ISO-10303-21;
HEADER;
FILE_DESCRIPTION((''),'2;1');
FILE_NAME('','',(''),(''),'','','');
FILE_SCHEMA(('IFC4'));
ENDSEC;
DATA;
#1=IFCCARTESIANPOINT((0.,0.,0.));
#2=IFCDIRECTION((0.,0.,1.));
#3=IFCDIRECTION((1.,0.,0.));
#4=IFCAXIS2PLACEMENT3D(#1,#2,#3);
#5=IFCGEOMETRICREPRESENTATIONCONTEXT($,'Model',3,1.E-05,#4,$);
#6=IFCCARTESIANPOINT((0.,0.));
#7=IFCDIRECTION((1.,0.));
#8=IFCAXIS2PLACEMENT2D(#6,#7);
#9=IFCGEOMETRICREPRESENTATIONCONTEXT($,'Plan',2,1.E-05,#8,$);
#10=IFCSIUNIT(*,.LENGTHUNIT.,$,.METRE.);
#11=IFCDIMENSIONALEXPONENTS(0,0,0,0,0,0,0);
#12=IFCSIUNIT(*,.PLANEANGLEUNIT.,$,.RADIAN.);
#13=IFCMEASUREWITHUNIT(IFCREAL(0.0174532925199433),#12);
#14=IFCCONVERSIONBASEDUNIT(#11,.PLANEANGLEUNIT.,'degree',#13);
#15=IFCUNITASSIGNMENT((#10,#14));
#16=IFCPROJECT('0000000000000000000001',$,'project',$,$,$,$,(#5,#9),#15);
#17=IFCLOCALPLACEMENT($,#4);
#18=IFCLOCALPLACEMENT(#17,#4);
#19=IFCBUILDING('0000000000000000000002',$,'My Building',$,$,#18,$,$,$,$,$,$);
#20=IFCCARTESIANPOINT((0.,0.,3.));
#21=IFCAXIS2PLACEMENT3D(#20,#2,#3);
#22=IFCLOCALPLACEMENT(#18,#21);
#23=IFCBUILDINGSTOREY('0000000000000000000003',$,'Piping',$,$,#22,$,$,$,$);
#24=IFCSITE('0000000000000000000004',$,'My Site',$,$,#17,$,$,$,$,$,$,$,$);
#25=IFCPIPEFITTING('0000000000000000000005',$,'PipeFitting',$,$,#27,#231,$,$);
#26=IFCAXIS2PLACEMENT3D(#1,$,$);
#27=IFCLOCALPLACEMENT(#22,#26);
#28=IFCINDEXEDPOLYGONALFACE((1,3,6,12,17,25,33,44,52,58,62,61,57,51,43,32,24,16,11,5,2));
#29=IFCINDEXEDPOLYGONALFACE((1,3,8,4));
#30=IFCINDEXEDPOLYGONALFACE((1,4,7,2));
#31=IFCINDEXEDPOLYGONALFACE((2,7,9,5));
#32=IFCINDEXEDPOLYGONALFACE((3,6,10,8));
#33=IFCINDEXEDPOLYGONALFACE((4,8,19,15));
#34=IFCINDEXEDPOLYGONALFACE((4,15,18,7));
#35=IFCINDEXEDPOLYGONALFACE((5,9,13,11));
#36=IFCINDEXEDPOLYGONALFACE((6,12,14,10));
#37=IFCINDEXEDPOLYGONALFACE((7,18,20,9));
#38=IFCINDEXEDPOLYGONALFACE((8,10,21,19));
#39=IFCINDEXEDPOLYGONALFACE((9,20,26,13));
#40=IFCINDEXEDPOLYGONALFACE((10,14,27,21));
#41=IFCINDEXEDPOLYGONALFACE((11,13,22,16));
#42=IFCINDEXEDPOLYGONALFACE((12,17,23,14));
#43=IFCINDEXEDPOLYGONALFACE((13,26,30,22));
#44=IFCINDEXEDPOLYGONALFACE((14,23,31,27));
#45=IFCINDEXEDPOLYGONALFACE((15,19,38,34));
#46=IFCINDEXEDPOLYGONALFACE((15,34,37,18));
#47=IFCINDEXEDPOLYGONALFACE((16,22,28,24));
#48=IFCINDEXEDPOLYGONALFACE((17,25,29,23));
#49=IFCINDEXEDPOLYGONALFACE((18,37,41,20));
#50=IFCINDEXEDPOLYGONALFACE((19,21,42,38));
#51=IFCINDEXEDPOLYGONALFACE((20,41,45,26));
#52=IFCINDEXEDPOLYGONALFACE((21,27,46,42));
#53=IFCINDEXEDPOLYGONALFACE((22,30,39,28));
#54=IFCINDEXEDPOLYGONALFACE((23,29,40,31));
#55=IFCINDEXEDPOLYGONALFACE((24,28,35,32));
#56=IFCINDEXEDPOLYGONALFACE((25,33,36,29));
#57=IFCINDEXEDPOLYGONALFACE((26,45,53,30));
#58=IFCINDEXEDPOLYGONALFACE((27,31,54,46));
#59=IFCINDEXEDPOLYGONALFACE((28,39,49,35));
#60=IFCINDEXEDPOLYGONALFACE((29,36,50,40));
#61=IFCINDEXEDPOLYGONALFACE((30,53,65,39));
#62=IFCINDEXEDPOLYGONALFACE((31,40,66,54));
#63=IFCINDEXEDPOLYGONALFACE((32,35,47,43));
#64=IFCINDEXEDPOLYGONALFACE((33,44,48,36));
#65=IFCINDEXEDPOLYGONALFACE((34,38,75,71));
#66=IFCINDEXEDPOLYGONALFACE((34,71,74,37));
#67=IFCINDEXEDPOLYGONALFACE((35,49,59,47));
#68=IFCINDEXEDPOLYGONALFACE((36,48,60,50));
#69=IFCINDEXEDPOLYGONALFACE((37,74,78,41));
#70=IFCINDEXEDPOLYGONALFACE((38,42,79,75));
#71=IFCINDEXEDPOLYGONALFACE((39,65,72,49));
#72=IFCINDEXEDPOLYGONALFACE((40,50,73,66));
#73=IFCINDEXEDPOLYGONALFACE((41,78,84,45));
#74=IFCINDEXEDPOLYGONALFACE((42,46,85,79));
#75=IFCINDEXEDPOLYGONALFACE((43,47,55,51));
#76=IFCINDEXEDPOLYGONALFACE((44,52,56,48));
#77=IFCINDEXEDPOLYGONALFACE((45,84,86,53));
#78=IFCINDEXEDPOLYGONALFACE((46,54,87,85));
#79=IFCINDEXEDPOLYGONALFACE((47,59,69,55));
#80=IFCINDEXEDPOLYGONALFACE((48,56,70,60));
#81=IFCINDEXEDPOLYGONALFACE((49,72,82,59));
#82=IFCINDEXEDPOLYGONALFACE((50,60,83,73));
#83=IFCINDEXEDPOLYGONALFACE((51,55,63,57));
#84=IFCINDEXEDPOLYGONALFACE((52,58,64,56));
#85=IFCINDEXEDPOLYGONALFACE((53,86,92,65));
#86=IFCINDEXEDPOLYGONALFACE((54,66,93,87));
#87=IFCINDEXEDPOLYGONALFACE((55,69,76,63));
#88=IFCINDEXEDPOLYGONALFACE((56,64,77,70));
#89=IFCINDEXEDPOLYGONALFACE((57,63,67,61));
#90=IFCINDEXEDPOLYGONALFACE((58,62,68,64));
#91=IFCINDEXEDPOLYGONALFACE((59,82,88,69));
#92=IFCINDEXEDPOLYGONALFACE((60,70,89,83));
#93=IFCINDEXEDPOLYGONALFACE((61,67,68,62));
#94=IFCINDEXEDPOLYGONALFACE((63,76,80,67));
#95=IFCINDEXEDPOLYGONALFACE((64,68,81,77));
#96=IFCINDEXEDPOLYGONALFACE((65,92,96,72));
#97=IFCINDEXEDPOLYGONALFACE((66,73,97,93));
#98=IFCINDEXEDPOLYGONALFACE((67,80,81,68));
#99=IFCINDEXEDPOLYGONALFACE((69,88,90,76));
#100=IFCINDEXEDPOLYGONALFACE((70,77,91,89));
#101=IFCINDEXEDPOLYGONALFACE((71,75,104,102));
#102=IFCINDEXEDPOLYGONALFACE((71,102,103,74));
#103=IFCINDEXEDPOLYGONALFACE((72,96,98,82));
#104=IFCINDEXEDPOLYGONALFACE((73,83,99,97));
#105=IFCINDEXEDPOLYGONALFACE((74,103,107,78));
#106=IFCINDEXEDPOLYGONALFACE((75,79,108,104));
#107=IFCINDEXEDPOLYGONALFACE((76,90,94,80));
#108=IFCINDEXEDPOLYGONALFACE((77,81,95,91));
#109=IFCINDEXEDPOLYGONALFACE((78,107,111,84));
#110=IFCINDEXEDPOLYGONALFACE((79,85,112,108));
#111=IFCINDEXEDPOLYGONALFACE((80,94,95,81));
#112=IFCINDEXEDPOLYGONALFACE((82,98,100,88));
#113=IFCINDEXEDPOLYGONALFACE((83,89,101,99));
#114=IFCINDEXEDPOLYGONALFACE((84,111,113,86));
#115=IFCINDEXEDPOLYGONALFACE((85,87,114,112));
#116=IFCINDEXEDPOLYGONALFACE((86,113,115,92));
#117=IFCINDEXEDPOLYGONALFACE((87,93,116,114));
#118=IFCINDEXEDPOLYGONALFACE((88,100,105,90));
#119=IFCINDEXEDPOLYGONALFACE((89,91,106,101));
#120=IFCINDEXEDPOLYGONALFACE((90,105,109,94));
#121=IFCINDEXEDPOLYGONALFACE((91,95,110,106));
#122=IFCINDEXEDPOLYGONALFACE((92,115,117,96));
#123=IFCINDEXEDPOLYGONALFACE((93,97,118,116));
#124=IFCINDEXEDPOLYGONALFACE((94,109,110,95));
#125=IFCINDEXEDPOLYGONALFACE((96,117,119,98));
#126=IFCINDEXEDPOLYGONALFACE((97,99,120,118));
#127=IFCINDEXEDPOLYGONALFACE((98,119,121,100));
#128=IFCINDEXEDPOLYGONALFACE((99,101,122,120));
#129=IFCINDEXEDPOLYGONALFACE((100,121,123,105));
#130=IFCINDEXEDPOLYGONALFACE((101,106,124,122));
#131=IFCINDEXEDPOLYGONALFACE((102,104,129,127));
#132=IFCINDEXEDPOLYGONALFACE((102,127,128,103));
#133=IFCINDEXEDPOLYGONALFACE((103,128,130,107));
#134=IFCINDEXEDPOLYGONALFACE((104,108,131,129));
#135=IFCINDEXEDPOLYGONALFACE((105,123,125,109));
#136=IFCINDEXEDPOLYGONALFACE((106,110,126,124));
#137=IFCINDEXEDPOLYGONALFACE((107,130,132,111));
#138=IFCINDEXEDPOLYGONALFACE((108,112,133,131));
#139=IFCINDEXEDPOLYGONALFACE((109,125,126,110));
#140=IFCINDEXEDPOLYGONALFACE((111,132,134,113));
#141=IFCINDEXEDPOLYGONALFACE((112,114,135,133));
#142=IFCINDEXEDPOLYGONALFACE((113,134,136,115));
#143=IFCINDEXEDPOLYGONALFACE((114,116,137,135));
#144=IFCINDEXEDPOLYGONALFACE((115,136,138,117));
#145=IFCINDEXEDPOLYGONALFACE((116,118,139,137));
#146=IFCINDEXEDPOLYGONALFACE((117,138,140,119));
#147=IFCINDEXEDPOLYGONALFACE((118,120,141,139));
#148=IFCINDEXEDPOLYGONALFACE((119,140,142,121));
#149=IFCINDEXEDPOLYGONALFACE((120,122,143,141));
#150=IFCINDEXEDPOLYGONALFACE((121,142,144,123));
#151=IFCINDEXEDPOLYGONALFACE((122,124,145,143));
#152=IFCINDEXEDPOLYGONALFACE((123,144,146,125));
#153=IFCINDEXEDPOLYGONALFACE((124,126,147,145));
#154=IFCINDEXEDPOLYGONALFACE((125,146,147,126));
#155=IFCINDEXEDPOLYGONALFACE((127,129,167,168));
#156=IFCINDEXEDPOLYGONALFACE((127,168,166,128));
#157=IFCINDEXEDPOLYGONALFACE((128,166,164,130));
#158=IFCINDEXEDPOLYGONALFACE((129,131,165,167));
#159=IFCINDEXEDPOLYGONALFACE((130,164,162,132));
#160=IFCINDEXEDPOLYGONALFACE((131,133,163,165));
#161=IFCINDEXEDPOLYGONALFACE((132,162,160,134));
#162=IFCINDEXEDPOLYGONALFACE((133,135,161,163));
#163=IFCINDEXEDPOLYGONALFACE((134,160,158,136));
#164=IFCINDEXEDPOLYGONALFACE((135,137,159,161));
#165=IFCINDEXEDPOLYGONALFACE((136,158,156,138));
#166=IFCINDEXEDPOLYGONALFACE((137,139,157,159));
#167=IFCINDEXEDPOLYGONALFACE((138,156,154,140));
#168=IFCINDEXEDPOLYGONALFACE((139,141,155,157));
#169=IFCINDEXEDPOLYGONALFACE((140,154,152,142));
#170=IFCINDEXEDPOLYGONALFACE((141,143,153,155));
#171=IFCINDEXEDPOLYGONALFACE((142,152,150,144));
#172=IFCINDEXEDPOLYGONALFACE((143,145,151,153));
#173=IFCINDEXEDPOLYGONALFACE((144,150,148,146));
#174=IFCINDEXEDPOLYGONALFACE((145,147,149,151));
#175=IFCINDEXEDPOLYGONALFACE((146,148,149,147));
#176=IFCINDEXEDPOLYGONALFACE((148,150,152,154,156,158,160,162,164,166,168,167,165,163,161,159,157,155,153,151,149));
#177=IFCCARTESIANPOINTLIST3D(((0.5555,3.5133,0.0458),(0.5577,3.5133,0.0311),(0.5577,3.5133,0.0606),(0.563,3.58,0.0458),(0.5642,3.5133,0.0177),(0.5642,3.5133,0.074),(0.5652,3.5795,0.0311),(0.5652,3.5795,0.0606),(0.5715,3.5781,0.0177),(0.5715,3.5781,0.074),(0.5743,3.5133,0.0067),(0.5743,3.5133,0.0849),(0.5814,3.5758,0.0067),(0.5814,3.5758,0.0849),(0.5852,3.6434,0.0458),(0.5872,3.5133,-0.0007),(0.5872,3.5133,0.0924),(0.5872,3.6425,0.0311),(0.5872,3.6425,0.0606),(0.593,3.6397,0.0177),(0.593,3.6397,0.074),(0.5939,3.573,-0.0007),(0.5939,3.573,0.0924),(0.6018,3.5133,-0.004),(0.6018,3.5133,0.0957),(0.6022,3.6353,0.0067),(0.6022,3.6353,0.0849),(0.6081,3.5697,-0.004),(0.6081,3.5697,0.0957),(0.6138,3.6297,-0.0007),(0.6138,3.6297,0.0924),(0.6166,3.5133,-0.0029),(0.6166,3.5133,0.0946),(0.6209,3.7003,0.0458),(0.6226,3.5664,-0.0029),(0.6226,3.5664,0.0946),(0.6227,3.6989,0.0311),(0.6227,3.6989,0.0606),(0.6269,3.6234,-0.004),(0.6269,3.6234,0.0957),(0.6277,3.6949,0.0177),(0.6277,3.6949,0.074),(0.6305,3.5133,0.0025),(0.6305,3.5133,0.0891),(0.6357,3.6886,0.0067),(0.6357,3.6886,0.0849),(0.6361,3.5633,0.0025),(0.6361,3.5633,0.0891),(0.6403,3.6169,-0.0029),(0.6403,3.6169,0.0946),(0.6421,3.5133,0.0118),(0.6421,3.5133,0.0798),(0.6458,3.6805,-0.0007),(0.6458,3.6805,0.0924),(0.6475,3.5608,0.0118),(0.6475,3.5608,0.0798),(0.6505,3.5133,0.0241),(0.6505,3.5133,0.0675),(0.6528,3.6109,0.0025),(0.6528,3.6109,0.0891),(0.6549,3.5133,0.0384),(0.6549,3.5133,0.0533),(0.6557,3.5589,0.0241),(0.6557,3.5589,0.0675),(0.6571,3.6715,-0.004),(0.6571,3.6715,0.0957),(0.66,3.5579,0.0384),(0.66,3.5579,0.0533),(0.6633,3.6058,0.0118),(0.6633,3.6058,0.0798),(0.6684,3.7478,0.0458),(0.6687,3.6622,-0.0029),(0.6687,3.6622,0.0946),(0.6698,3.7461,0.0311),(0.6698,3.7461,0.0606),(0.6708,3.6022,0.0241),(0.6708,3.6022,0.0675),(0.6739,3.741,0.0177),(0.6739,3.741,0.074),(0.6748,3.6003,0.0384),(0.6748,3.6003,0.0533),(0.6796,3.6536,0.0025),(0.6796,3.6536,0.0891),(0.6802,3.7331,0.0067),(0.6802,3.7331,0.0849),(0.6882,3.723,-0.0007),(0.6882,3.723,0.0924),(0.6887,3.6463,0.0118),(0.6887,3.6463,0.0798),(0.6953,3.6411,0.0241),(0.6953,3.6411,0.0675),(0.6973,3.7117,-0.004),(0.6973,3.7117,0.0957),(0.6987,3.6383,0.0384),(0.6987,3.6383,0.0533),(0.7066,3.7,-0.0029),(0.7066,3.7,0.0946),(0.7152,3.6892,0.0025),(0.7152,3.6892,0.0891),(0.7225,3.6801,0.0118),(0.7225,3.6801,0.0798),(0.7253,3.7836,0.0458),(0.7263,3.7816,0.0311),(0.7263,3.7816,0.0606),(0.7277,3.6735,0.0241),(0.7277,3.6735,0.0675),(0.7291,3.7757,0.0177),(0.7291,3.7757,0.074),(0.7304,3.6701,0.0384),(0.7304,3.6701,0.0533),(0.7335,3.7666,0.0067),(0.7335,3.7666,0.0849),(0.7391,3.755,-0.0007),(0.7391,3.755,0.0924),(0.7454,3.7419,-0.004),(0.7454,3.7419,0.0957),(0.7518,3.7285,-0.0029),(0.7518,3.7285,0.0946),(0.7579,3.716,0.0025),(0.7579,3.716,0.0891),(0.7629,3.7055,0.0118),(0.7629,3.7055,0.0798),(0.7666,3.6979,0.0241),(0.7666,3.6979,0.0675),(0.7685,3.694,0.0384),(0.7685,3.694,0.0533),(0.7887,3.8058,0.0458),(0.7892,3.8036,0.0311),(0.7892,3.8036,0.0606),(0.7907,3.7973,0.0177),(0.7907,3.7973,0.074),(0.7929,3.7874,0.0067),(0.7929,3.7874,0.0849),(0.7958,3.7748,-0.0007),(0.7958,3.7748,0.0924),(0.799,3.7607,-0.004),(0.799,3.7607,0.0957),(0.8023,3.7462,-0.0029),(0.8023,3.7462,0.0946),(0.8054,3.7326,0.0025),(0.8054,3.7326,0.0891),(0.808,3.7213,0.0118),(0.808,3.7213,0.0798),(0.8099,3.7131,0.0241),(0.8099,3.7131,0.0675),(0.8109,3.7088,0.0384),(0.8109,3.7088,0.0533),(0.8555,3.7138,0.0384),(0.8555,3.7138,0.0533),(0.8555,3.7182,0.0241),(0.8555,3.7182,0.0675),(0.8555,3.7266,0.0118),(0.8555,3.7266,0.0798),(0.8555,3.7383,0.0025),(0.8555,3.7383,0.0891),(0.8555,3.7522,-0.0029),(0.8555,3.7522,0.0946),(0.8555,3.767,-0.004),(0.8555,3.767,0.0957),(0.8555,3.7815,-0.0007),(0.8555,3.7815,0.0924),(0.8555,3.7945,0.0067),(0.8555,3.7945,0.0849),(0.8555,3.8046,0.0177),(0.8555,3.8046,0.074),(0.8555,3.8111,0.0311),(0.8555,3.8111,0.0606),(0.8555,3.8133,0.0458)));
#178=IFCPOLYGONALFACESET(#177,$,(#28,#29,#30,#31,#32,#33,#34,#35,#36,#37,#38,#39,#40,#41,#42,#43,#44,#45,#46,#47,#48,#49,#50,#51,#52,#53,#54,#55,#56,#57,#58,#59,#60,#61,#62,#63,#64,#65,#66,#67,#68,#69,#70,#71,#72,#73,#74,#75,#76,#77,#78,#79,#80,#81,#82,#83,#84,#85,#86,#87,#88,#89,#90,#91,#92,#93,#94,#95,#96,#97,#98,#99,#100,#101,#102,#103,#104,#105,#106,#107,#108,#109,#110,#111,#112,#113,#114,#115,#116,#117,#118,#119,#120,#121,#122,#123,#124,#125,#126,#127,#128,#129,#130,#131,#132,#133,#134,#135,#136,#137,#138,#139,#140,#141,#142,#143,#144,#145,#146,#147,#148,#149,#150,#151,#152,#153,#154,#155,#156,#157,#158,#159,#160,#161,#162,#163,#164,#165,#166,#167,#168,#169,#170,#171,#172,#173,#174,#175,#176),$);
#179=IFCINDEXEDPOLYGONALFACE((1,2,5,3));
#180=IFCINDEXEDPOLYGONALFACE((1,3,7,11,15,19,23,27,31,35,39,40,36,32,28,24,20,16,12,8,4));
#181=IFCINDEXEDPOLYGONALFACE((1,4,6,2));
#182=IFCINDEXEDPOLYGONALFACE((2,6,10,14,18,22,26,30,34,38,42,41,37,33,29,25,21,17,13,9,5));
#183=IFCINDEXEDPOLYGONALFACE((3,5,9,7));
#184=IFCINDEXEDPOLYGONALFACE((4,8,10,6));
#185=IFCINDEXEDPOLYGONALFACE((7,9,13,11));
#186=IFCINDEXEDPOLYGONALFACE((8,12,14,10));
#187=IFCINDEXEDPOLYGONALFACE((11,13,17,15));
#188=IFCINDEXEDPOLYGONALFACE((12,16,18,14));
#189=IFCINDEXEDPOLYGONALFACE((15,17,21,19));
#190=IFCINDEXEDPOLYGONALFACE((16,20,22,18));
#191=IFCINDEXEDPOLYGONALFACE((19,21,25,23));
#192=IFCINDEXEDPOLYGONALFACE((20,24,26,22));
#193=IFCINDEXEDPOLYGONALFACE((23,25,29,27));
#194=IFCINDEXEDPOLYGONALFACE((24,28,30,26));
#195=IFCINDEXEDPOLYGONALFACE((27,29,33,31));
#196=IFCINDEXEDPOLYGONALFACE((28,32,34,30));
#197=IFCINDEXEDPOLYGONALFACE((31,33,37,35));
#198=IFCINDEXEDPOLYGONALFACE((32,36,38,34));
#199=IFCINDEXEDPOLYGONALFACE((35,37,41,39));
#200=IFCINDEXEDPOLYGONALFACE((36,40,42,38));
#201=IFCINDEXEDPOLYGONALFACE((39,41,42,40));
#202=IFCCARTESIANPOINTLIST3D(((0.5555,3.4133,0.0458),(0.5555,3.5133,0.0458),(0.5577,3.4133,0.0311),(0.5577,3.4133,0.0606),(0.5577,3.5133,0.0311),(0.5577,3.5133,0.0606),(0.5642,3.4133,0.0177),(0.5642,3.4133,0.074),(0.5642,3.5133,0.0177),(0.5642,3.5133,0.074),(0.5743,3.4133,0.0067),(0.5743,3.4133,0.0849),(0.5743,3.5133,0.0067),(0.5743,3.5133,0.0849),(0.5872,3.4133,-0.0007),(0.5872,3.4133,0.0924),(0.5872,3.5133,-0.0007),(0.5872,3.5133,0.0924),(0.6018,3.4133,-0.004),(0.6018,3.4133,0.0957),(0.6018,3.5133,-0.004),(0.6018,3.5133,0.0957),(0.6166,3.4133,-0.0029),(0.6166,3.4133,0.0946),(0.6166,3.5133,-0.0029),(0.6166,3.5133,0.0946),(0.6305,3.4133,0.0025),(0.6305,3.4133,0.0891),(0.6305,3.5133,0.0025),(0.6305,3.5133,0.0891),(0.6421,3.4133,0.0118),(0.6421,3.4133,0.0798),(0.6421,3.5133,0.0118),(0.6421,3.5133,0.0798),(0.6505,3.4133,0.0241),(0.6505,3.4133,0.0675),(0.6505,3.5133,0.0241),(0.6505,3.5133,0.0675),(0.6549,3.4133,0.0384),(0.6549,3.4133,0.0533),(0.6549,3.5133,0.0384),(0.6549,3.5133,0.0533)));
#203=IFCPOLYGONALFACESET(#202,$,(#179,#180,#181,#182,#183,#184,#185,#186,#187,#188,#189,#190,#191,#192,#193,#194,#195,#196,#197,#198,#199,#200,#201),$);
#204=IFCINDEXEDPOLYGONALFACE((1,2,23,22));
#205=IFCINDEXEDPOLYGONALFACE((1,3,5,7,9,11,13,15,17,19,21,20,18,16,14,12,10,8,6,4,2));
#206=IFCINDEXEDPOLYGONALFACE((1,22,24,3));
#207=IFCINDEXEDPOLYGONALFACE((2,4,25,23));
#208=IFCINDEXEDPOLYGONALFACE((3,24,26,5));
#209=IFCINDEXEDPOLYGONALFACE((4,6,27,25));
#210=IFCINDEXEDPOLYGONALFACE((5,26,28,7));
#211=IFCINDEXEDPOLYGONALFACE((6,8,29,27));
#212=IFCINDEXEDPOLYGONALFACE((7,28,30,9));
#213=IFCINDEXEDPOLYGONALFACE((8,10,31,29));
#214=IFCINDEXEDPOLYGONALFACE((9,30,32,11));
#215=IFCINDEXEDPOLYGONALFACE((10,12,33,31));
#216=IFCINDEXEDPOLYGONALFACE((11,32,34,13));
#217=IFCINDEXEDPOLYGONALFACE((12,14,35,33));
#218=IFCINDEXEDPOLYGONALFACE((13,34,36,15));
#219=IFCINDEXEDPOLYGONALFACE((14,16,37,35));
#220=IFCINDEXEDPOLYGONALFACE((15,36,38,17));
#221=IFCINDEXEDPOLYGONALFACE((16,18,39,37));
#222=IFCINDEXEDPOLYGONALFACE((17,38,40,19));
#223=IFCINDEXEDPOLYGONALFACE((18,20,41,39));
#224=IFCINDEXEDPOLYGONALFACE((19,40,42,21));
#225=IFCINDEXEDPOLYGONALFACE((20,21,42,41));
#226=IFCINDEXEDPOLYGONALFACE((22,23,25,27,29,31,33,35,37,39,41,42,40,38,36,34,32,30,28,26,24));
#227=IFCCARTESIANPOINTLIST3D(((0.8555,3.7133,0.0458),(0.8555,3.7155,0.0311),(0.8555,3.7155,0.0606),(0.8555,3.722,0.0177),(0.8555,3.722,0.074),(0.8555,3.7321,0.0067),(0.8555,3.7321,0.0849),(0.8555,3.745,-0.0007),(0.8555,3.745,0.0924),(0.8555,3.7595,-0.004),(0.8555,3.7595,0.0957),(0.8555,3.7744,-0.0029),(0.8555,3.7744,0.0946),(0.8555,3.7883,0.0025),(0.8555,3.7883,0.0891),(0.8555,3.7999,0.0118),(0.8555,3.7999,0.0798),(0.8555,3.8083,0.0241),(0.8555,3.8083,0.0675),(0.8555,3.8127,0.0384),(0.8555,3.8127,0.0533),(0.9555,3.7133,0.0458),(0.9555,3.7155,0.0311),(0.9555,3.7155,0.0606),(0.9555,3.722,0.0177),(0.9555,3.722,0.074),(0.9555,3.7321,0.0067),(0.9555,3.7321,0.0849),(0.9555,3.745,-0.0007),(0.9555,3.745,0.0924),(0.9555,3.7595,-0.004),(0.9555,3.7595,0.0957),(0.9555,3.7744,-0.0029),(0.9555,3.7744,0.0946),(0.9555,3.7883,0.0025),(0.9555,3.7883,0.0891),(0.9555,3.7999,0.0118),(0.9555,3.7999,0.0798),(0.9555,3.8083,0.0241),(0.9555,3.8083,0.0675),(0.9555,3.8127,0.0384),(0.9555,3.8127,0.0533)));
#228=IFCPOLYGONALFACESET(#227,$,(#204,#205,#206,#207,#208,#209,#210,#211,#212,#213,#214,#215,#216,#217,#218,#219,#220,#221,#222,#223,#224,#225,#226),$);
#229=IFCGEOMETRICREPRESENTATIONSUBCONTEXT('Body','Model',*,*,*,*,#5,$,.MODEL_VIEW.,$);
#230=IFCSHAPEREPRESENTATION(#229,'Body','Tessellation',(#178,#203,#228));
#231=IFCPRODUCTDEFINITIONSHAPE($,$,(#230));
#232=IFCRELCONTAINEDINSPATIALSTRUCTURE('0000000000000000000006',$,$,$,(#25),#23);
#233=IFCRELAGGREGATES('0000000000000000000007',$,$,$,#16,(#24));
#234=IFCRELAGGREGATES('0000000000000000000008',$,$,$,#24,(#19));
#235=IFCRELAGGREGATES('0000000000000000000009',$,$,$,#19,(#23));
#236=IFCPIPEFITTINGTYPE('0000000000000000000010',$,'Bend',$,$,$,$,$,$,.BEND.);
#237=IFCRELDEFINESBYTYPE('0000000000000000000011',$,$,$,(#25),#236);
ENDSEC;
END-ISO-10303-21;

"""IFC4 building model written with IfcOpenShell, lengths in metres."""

from ifc_helpers import new_model, entity, si_unit, converted_unit, frame, origin_with_axes, origin_2d_with_axis, place, context, subcontext, project, spatial, circle, extrude, source, transform, mapped, type_object, type_shapes, element, save


model = new_model("IFC4")

# Units and contexts
model_context = context("Model", 3, precision=1e-05, world=origin_with_axes())
plan_context = context("Plan", 2, precision=1e-05, world=origin_2d_with_axis())
body_context = subcontext(model_context, "Body", "Model", "MODEL_VIEW")
ifc_project = project(units=[si_unit("LENGTHUNIT", "METRE"), converted_unit("PLANEANGLEUNIT", "degree", entity("IfcReal", 0.0174532925199433), si_unit("PLANEANGLEUNIT", "RADIAN"), dimensions=[0, 0, 0, 0, 0, 0, 0])], contexts=[model_context, plan_context])

# Site, building, storey
site_placement = place(None, origin_with_axes())
site = spatial("IfcSite", under=ifc_project, at=site_placement, Name="My Site")
building_placement = place(site_placement, origin_with_axes())
building = spatial("IfcBuilding", under=site, at=building_placement, Name="My Building")
storey_placement = place(building_placement, frame((0.0, 0.0, 3.0), z_axis=(0.0, 0.0, 1.0), x_axis=(1.0, 0.0, 0.0)))
storey = spatial("IfcBuildingStorey", under=building, at=storey_placement, Name="Piping")

# Pipe fitting
pipe_fitting_type_1 = type_object("IfcPipeFittingType", Name="Bend", PredefinedType="BEND")
shared_shape_1 = source(origin_with_axes(), body_context, "Body", "SolidModel", [
    entity("IfcSweptDiskSolid", entity("IfcIndexedPolyCurve", entity("IfcCartesianPointList3D", [[0.0, 0.0, 0.1], [-0.0732, 0.0, 0.2768], [-0.25, 0.0, 0.35]]), [entity("IfcArcIndex", [1, 2, 3])]), 0.05),
    extrude(circle(Radius=0.05), origin_with_axes(), (0.0, 0.0, 1.0), 0.1),
    extrude(circle(Radius=0.05), frame((-0.25, 0.0, 0.35), z_axis=(-1.0, 0.0, 0.0), x_axis=(0.0, 0.0, -1.0)), (0.0, 0.0, 1.0), 0.1),
])
type_shapes(pipe_fitting_type_1, [shared_shape_1])
pipe_fitting_placement = place(storey_placement, frame((0.6055, 3.4133, 0.0458), z_axis=(0.0, 1.0, 0.0), x_axis=(-1.0, 0.0, 0.0)))
element("IfcPipeFitting", 1, at=pipe_fitting_placement, inside=storey, type_object=pipe_fitting_type_1, Name="PipeFitting", context=body_context, shape_type="MappedRepresentation", body=[
    mapped(shared_shape_1, transform((0.0, 0.0, 0.0), x_axis=(1.0, 0.0, 0.0), y_axis=(0.0, 1.0, 0.0), z_axis=(0.0, 0.0, 1.0), scale=1.0)),
])

save(model, "model.ifc")
